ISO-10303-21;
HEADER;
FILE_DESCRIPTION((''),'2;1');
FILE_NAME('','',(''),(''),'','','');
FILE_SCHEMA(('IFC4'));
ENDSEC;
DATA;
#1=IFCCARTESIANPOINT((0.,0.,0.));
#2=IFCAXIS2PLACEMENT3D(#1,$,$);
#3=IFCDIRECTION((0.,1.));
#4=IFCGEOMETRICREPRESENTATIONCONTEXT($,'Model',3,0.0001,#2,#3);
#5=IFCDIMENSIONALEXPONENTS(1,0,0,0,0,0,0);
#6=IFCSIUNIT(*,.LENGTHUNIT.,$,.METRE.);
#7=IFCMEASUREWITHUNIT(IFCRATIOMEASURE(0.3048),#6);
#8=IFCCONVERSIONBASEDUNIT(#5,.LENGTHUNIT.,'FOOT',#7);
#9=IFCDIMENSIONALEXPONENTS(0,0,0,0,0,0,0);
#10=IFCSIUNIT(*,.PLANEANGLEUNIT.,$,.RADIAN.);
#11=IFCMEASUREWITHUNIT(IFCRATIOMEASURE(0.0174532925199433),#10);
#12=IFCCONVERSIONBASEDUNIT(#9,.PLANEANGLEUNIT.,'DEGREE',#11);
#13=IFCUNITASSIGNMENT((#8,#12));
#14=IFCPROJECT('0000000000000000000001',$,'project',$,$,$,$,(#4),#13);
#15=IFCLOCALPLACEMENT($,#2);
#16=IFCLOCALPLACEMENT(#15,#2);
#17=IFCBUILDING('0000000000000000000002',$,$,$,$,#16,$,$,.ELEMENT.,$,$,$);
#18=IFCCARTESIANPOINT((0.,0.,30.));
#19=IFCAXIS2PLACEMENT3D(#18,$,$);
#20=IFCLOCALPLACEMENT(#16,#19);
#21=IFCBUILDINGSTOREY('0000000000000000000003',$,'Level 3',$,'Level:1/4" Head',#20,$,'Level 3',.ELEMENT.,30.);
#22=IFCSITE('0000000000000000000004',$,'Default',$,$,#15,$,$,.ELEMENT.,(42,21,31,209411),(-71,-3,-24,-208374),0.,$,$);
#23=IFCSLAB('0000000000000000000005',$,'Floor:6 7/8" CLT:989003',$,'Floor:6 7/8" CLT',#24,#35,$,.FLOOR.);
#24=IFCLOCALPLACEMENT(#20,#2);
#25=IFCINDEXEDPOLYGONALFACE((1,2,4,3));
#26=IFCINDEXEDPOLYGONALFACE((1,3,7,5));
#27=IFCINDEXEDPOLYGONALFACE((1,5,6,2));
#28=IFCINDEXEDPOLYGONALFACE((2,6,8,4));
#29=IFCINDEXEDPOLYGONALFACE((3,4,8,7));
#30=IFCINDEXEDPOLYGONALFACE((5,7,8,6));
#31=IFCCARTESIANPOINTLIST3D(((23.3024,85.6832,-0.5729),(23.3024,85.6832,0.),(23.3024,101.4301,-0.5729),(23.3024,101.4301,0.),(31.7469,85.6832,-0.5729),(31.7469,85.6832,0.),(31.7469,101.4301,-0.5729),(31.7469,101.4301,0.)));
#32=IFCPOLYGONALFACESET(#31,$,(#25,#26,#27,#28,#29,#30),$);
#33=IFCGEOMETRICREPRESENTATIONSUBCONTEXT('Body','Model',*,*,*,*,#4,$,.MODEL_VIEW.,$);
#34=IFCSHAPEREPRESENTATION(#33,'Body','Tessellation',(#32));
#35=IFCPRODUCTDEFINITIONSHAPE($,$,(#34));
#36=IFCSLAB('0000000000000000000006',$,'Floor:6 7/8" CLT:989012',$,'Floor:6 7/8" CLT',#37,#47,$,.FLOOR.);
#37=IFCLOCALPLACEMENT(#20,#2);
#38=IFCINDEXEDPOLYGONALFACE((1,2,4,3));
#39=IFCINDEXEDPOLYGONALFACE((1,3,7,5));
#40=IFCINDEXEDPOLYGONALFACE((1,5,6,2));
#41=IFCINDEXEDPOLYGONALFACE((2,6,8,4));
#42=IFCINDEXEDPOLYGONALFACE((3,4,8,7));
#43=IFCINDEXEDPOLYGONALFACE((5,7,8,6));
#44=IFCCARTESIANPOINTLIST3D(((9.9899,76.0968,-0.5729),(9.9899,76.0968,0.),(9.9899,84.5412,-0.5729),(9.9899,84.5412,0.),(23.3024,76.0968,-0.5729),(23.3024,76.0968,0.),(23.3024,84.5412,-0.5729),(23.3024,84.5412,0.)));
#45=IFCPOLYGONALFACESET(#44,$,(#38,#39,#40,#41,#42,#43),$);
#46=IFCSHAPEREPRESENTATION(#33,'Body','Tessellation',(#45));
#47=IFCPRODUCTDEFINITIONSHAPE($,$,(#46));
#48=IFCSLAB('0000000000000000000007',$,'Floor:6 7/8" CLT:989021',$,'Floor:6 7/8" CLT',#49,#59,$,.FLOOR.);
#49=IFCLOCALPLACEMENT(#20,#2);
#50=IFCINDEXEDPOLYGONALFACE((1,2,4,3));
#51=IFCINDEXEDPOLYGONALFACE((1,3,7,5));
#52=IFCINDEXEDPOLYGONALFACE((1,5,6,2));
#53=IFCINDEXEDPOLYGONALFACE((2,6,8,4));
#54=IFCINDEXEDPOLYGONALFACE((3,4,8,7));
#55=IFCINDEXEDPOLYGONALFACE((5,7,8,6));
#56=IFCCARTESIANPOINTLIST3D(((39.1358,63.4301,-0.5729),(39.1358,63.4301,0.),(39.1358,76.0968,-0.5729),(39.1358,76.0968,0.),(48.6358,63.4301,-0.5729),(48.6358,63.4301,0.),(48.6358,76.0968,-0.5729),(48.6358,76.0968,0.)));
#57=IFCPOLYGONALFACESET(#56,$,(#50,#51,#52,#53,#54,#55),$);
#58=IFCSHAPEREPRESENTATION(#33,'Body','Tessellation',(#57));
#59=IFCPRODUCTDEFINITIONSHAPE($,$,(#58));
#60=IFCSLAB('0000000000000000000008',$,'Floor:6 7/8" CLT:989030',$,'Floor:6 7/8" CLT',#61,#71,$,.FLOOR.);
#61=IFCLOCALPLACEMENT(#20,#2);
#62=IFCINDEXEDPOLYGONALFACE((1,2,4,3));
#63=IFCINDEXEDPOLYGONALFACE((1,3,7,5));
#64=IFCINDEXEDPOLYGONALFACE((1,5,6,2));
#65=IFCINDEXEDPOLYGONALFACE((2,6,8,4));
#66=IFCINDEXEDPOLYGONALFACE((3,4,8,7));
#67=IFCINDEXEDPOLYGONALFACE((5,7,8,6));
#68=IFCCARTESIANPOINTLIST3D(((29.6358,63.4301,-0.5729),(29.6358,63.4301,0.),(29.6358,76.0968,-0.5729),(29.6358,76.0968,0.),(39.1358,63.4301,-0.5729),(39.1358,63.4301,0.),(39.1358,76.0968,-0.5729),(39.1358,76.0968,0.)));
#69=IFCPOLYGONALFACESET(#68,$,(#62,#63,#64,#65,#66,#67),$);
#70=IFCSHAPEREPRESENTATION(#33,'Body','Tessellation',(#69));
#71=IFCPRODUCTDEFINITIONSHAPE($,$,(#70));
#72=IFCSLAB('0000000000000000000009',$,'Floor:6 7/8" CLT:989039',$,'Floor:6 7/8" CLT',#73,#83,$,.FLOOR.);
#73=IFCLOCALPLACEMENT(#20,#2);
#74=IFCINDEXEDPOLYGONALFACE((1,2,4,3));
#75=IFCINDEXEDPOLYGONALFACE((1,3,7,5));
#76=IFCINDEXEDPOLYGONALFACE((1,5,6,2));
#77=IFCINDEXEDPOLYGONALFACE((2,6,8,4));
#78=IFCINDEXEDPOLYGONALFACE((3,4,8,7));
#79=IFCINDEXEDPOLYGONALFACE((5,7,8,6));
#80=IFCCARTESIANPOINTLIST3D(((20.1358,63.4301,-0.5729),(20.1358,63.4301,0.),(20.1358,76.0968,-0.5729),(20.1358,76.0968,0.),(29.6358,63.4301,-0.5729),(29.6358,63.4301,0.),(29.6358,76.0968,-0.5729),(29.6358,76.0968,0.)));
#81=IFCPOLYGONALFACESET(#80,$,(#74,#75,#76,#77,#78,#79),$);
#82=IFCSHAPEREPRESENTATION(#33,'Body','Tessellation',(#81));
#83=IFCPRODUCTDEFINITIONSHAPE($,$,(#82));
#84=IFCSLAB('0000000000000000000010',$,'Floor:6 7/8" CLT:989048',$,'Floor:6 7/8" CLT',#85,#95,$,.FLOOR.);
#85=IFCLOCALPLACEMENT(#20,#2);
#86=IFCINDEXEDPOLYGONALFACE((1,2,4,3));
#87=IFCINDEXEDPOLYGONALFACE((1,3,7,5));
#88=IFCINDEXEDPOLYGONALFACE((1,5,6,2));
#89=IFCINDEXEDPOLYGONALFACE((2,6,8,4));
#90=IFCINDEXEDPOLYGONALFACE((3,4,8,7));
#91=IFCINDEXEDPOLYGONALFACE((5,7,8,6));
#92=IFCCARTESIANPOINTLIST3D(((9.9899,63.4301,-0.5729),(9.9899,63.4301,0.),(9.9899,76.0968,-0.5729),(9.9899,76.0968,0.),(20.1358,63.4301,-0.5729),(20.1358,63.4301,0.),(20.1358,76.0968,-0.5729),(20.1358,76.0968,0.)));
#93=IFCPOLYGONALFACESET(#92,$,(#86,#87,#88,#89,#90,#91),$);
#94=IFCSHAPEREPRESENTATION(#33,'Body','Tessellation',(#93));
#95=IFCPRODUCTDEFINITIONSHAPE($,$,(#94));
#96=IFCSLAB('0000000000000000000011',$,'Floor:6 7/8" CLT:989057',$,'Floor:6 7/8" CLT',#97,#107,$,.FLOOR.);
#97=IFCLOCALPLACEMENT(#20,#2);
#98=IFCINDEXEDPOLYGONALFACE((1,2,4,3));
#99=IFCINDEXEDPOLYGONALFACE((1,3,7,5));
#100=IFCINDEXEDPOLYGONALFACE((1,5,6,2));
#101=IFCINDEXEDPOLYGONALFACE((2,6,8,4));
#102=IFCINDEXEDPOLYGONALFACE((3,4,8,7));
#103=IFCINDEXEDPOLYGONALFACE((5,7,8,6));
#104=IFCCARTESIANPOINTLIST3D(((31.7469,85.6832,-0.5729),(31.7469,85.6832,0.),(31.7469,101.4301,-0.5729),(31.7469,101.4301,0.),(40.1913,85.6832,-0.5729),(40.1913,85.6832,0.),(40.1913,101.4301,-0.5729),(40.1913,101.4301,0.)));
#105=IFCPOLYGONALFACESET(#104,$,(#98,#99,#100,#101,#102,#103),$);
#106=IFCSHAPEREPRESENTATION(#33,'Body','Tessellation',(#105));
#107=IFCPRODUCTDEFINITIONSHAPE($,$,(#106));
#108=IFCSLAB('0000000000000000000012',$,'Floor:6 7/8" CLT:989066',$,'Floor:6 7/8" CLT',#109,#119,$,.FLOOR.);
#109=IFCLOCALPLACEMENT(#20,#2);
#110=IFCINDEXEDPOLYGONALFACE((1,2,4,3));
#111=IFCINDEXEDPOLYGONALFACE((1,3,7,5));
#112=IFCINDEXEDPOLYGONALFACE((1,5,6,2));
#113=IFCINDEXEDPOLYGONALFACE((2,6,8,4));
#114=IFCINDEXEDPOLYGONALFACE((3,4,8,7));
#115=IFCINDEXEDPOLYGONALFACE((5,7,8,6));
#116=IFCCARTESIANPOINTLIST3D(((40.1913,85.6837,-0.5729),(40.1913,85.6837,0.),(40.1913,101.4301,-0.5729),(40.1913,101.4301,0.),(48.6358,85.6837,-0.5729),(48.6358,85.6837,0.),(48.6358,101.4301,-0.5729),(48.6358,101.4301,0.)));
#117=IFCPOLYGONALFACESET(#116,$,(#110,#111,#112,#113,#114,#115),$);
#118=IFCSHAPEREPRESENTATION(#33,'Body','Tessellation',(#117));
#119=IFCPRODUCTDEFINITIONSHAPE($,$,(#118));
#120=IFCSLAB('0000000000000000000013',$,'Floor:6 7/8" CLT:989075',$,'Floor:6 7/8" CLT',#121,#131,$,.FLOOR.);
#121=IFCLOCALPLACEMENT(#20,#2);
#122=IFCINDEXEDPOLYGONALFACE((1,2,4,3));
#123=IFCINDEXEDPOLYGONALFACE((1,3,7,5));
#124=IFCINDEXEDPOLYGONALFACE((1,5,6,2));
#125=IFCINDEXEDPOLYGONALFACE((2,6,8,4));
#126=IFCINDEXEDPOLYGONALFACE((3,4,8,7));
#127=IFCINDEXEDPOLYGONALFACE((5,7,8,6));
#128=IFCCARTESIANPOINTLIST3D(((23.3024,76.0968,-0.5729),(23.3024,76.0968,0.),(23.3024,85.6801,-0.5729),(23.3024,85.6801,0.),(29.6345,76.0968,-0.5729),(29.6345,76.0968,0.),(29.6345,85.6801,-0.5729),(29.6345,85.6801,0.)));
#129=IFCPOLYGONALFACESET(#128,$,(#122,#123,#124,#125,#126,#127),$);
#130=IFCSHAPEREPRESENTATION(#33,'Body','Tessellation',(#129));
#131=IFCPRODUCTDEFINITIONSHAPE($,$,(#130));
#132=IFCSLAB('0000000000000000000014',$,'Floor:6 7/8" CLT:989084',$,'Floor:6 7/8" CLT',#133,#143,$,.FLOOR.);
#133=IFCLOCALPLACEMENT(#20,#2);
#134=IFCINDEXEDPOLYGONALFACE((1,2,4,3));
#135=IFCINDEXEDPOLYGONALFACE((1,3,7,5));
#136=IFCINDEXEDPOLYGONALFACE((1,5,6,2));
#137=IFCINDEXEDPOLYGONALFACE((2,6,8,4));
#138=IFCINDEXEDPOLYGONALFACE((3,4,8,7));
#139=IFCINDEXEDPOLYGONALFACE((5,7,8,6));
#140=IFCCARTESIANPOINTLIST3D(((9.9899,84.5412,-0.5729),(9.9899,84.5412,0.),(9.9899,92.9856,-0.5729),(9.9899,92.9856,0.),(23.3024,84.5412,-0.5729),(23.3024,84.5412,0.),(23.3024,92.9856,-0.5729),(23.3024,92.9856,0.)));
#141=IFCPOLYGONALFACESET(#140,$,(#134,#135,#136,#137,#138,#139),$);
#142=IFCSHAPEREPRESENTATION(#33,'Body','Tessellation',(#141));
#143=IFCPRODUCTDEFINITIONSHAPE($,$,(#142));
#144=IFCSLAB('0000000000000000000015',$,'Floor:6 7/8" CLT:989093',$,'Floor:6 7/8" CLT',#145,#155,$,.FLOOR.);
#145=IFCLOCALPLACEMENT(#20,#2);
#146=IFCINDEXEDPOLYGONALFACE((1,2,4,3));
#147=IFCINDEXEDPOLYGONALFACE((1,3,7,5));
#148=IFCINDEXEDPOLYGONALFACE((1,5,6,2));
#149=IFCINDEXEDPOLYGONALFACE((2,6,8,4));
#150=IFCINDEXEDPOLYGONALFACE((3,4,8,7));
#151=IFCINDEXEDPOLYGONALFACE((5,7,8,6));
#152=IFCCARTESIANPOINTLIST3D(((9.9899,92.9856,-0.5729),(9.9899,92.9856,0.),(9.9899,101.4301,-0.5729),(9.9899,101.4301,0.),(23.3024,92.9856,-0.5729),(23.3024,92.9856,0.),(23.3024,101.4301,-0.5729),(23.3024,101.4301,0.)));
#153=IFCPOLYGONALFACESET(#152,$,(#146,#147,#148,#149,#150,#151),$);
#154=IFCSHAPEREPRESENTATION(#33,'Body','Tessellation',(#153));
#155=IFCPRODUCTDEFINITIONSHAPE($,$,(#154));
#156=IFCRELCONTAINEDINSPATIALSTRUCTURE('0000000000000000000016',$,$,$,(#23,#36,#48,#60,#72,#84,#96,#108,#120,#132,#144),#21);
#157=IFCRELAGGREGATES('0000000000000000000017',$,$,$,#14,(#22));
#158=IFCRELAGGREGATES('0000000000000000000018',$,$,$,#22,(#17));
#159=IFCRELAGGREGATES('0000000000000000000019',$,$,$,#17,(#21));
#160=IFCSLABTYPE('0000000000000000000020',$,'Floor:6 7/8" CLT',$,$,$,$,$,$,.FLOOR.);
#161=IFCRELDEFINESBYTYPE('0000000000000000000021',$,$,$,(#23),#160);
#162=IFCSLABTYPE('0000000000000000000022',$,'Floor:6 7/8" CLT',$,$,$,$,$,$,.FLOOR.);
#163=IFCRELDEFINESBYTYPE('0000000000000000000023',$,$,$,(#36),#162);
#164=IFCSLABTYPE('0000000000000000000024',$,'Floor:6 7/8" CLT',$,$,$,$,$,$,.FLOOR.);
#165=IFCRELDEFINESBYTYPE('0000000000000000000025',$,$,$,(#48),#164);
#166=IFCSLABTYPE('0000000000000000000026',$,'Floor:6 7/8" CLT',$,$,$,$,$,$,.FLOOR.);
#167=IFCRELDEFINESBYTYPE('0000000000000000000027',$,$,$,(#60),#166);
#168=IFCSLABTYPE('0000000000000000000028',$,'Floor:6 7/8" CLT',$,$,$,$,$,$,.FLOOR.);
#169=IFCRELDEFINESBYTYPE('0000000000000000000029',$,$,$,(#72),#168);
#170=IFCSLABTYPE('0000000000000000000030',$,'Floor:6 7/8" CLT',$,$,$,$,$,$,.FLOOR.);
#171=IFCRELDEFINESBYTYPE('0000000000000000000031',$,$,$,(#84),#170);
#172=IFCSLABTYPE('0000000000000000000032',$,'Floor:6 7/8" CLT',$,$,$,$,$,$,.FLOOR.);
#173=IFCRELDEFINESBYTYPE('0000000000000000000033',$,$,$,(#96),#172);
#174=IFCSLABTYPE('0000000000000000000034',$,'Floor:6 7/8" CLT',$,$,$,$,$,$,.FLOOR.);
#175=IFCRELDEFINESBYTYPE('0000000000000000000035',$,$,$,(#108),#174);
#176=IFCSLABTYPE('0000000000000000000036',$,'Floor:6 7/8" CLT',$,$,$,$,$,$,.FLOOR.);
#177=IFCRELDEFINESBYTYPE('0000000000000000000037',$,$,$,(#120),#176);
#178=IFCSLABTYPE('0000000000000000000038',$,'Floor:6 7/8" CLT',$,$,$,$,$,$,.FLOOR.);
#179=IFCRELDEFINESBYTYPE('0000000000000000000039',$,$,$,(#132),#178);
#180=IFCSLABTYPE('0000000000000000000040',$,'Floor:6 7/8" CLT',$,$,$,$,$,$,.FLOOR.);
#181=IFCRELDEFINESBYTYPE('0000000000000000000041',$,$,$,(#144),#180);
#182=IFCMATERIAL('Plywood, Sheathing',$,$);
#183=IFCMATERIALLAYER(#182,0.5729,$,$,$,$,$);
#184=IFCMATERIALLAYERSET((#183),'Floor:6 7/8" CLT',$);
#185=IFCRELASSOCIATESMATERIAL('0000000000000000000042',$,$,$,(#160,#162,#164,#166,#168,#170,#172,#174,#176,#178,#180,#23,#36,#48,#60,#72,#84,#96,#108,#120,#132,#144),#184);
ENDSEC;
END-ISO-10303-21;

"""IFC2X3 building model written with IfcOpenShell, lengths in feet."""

from ifc_helpers import new_model, entity, si_unit, converted_unit, direction, frame, frame_2d, origin, place, context, subcontext, project, spatial, rectangle, extrude, material, layer, layer_set, layer_usage, type_object, element, save


model = new_model("IFC2X3")

# Units and contexts
model_context = context("Model", 3, precision=0.0001, world=origin(), true_north=direction((0.0, 1.0)))
body_context = subcontext(model_context, "Body", "Model", "MODEL_VIEW")
ifc_project = project(units=[converted_unit("LENGTHUNIT", "FOOT", entity("IfcRatioMeasure", 0.3048), si_unit("LENGTHUNIT", "METRE"), dimensions=[1, 0, 0, 0, 0, 0, 0]), converted_unit("PLANEANGLEUNIT", "DEGREE", entity("IfcRatioMeasure", 0.0174532925199433), si_unit("PLANEANGLEUNIT", "RADIAN"), dimensions=[0, 0, 0, 0, 0, 0, 0])], contexts=[model_context])

# Site, building, storey
site_placement = place(None, origin())
site = spatial("IfcSite", under=ifc_project, at=site_placement, Name="Default", CompositionType="ELEMENT", RefLatitude=(42, 21, 31, 209411), RefLongitude=(-71, -3, -24, -208374), RefElevation=0.0)
building_placement = place(site_placement, origin())
building = spatial("IfcBuilding", under=site, at=building_placement, CompositionType="ELEMENT")
storey_placement = place(building_placement, frame((0.0, 0.0, 30.0)))
storey = spatial("IfcBuildingStorey", under=building, at=storey_placement, Name="Level 3", ObjectType="Level:1/4\" Head", LongName="Level 3", CompositionType="ELEMENT", Elevation=30.0)

# Slabs
ifc_material_1 = material(Name="Plywood, Sheathing")
ifc_layer = layer(ifc_material_1, 0.5729)
ifc_layer_set = layer_set([ifc_layer], Name="Floor:6 7/8\" CLT")
ifc_layer_usage_1 = layer_usage(ifc_layer_set, "AXIS3", "POSITIVE", 0.0)
slab_type_1 = type_object("IfcSlabType", Name="Floor:6 7/8\" CLT", PredefinedType="FLOOR", material=ifc_layer_set)
slab_1_placement = place(storey_placement, origin())
element("IfcSlab", 1, at=slab_1_placement, inside=storey, type_object=slab_type_1, material=ifc_layer_usage_1, Name="Floor:6 7/8\" CLT:989003", ObjectType="Floor:6 7/8\" CLT", PredefinedType="FLOOR", context=body_context, shape_type="SweptSolid", body=[
    extrude(rectangle(XDim=15.7469, YDim=8.4444, at=frame_2d((0.0, 0.0), x_axis=(1.0, 0.0))), frame((27.5247, 93.5566, 0.0), z_axis=(0.0, 0.0, -1.0), x_axis=(0.0, 1.0, 0.0)), (0.0, 0.0, 1.0), 0.5729),
])
ifc_layer_usage_2 = layer_usage(ifc_layer_set, "AXIS3", "POSITIVE", 0.0)
slab_type_2 = type_object("IfcSlabType", Name="Floor:6 7/8\" CLT", PredefinedType="FLOOR", material=ifc_layer_set)
slab_2_placement = place(storey_placement, origin())
element("IfcSlab", 2, at=slab_2_placement, inside=storey, type_object=slab_type_2, material=ifc_layer_usage_2, Name="Floor:6 7/8\" CLT:989012", ObjectType="Floor:6 7/8\" CLT", PredefinedType="FLOOR", context=body_context, shape_type="SweptSolid", body=[
    extrude(rectangle(XDim=8.4444, YDim=13.3125, at=frame_2d((0.0, 0.0), x_axis=(1.0, 0.0))), frame((16.6462, 80.319, 0.0), z_axis=(0.0, 0.0, -1.0), x_axis=(0.0, 1.0, 0.0)), (0.0, 0.0, 1.0), 0.5729),
])
ifc_layer_usage_3 = layer_usage(ifc_layer_set, "AXIS3", "POSITIVE", 0.0)
slab_type_3 = type_object("IfcSlabType", Name="Floor:6 7/8\" CLT", PredefinedType="FLOOR", material=ifc_layer_set)
slab_3_placement = place(storey_placement, origin())
element("IfcSlab", 3, at=slab_3_placement, inside=storey, type_object=slab_type_3, material=ifc_layer_usage_3, Name="Floor:6 7/8\" CLT:989021", ObjectType="Floor:6 7/8\" CLT", PredefinedType="FLOOR", context=body_context, shape_type="SweptSolid", body=[
    extrude(rectangle(XDim=12.6667, YDim=9.5, at=frame_2d((0.0, 0.0), x_axis=(1.0, 0.0))), frame((43.8858, 69.7634, 0.0), z_axis=(0.0, 0.0, -1.0), x_axis=(0.0, 1.0, 0.0)), (0.0, 0.0, 1.0), 0.5729),
])
ifc_layer_usage_4 = layer_usage(ifc_layer_set, "AXIS3", "POSITIVE", 0.0)
slab_type_4 = type_object("IfcSlabType", Name="Floor:6 7/8\" CLT", PredefinedType="FLOOR", material=ifc_layer_set)
slab_4_placement = place(storey_placement, origin())
element("IfcSlab", 4, at=slab_4_placement, inside=storey, type_object=slab_type_4, material=ifc_layer_usage_4, Name="Floor:6 7/8\" CLT:989030", ObjectType="Floor:6 7/8\" CLT", PredefinedType="FLOOR", context=body_context, shape_type="SweptSolid", body=[
    extrude(rectangle(XDim=12.6667, YDim=9.5, at=frame_2d((0.0, 0.0), x_axis=(1.0, 0.0))), frame((34.3858, 69.7634, 0.0), z_axis=(0.0, 0.0, -1.0), x_axis=(0.0, 1.0, 0.0)), (0.0, 0.0, 1.0), 0.5729),
])
ifc_layer_usage_5 = layer_usage(ifc_layer_set, "AXIS3", "POSITIVE", 0.0)
slab_type_5 = type_object("IfcSlabType", Name="Floor:6 7/8\" CLT", PredefinedType="FLOOR", material=ifc_layer_set)
slab_5_placement = place(storey_placement, origin())
element("IfcSlab", 5, at=slab_5_placement, inside=storey, type_object=slab_type_5, material=ifc_layer_usage_5, Name="Floor:6 7/8\" CLT:989039", ObjectType="Floor:6 7/8\" CLT", PredefinedType="FLOOR", context=body_context, shape_type="SweptSolid", body=[
    extrude(rectangle(XDim=12.6667, YDim=9.5, at=frame_2d((0.0, 0.0), x_axis=(1.0, 0.0))), frame((24.8858, 69.7634, 0.0), z_axis=(0.0, 0.0, -1.0), x_axis=(0.0, 1.0, 0.0)), (0.0, 0.0, 1.0), 0.5729),
])
ifc_layer_usage_6 = layer_usage(ifc_layer_set, "AXIS3", "POSITIVE", 0.0)
slab_type_6 = type_object("IfcSlabType", Name="Floor:6 7/8\" CLT", PredefinedType="FLOOR", material=ifc_layer_set)
slab_6_placement = place(storey_placement, origin())
element("IfcSlab", 6, at=slab_6_placement, inside=storey, type_object=slab_type_6, material=ifc_layer_usage_6, Name="Floor:6 7/8\" CLT:989048", ObjectType="Floor:6 7/8\" CLT", PredefinedType="FLOOR", context=body_context, shape_type="SweptSolid", body=[
    extrude(rectangle(XDim=12.6667, YDim=10.1458, at=frame_2d((0.0, 0.0), x_axis=(1.0, 0.0))), frame((15.0629, 69.7634, 0.0), z_axis=(0.0, 0.0, -1.0), x_axis=(0.0, 1.0, 0.0)), (0.0, 0.0, 1.0), 0.5729),
])
ifc_layer_usage_7 = layer_usage(ifc_layer_set, "AXIS3", "POSITIVE", 0.0)
slab_type_7 = type_object("IfcSlabType", Name="Floor:6 7/8\" CLT", PredefinedType="FLOOR", material=ifc_layer_set)
slab_7_placement = place(storey_placement, origin())
element("IfcSlab", 7, at=slab_7_placement, inside=storey, type_object=slab_type_7, material=ifc_layer_usage_7, Name="Floor:6 7/8\" CLT:989057", ObjectType="Floor:6 7/8\" CLT", PredefinedType="FLOOR", context=body_context, shape_type="SweptSolid", body=[
    extrude(rectangle(XDim=15.7469, YDim=8.4444, at=frame_2d((0.0, 0.0), x_axis=(1.0, 0.0))), frame((35.9691, 93.5566, 0.0), z_axis=(0.0, 0.0, -1.0), x_axis=(0.0, 1.0, 0.0)), (0.0, 0.0, 1.0), 0.5729),
])
ifc_layer_usage_8 = layer_usage(ifc_layer_set, "AXIS3", "POSITIVE", 0.0)
slab_type_8 = type_object("IfcSlabType", Name="Floor:6 7/8\" CLT", PredefinedType="FLOOR", material=ifc_layer_set)
slab_8_placement = place(storey_placement, origin())
element("IfcSlab", 8, at=slab_8_placement, inside=storey, type_object=slab_type_8, material=ifc_layer_usage_8, Name="Floor:6 7/8\" CLT:989066", ObjectType="Floor:6 7/8\" CLT", PredefinedType="FLOOR", context=body_context, shape_type="SweptSolid", body=[
    extrude(rectangle(XDim=15.7464, YDim=8.4444, at=frame_2d((0.0, 0.0), x_axis=(1.0, 0.0))), frame((44.4136, 93.5569, 0.0), z_axis=(0.0, 0.0, -1.0), x_axis=(0.0, 1.0, 0.0)), (0.0, 0.0, 1.0), 0.5729),
])
ifc_layer_usage_9 = layer_usage(ifc_layer_set, "AXIS3", "POSITIVE", 0.0)
slab_type_9 = type_object("IfcSlabType", Name="Floor:6 7/8\" CLT", PredefinedType="FLOOR", material=ifc_layer_set)
slab_9_placement = place(storey_placement, origin())
element("IfcSlab", 9, at=slab_9_placement, inside=storey, type_object=slab_type_9, material=ifc_layer_usage_9, Name="Floor:6 7/8\" CLT:989075", ObjectType="Floor:6 7/8\" CLT", PredefinedType="FLOOR", context=body_context, shape_type="SweptSolid", body=[
    extrude(rectangle(XDim=9.5833, YDim=6.3321, at=frame_2d((0.0, 0.0), x_axis=(1.0, 0.0))), frame((26.4685, 80.8884, 0.0), z_axis=(0.0, 0.0, -1.0), x_axis=(0.0, 1.0, 0.0)), (0.0, 0.0, 1.0), 0.5729),
])
ifc_layer_usage_10 = layer_usage(ifc_layer_set, "AXIS3", "POSITIVE", 0.0)
slab_type_10 = type_object("IfcSlabType", Name="Floor:6 7/8\" CLT", PredefinedType="FLOOR", material=ifc_layer_set)
slab_10_placement = place(storey_placement, origin())
element("IfcSlab", 10, at=slab_10_placement, inside=storey, type_object=slab_type_10, material=ifc_layer_usage_10, Name="Floor:6 7/8\" CLT:989084", ObjectType="Floor:6 7/8\" CLT", PredefinedType="FLOOR", context=body_context, shape_type="SweptSolid", body=[
    extrude(rectangle(XDim=8.4444, YDim=13.3125, at=frame_2d((0.0, 0.0), x_axis=(1.0, 0.0))), frame((16.6462, 88.7634, 0.0), z_axis=(0.0, 0.0, -1.0), x_axis=(0.0, 1.0, 0.0)), (0.0, 0.0, 1.0), 0.5729),
])
ifc_layer_usage_11 = layer_usage(ifc_layer_set, "AXIS3", "POSITIVE", 0.0)
slab_type_11 = type_object("IfcSlabType", Name="Floor:6 7/8\" CLT", PredefinedType="FLOOR", material=ifc_layer_set)
slab_11_placement = place(storey_placement, origin())
element("IfcSlab", 11, at=slab_11_placement, inside=storey, type_object=slab_type_11, material=ifc_layer_usage_11, Name="Floor:6 7/8\" CLT:989093", ObjectType="Floor:6 7/8\" CLT", PredefinedType="FLOOR", context=body_context, shape_type="SweptSolid", body=[
    extrude(rectangle(XDim=8.4444, YDim=13.3125, at=frame_2d((0.0, 0.0), x_axis=(1.0, 0.0))), frame((16.6462, 97.2079, 0.0), z_axis=(0.0, 0.0, -1.0), x_axis=(0.0, 1.0, 0.0)), (0.0, 0.0, 1.0), 0.5729),
])

save(model, "model.ifc")
